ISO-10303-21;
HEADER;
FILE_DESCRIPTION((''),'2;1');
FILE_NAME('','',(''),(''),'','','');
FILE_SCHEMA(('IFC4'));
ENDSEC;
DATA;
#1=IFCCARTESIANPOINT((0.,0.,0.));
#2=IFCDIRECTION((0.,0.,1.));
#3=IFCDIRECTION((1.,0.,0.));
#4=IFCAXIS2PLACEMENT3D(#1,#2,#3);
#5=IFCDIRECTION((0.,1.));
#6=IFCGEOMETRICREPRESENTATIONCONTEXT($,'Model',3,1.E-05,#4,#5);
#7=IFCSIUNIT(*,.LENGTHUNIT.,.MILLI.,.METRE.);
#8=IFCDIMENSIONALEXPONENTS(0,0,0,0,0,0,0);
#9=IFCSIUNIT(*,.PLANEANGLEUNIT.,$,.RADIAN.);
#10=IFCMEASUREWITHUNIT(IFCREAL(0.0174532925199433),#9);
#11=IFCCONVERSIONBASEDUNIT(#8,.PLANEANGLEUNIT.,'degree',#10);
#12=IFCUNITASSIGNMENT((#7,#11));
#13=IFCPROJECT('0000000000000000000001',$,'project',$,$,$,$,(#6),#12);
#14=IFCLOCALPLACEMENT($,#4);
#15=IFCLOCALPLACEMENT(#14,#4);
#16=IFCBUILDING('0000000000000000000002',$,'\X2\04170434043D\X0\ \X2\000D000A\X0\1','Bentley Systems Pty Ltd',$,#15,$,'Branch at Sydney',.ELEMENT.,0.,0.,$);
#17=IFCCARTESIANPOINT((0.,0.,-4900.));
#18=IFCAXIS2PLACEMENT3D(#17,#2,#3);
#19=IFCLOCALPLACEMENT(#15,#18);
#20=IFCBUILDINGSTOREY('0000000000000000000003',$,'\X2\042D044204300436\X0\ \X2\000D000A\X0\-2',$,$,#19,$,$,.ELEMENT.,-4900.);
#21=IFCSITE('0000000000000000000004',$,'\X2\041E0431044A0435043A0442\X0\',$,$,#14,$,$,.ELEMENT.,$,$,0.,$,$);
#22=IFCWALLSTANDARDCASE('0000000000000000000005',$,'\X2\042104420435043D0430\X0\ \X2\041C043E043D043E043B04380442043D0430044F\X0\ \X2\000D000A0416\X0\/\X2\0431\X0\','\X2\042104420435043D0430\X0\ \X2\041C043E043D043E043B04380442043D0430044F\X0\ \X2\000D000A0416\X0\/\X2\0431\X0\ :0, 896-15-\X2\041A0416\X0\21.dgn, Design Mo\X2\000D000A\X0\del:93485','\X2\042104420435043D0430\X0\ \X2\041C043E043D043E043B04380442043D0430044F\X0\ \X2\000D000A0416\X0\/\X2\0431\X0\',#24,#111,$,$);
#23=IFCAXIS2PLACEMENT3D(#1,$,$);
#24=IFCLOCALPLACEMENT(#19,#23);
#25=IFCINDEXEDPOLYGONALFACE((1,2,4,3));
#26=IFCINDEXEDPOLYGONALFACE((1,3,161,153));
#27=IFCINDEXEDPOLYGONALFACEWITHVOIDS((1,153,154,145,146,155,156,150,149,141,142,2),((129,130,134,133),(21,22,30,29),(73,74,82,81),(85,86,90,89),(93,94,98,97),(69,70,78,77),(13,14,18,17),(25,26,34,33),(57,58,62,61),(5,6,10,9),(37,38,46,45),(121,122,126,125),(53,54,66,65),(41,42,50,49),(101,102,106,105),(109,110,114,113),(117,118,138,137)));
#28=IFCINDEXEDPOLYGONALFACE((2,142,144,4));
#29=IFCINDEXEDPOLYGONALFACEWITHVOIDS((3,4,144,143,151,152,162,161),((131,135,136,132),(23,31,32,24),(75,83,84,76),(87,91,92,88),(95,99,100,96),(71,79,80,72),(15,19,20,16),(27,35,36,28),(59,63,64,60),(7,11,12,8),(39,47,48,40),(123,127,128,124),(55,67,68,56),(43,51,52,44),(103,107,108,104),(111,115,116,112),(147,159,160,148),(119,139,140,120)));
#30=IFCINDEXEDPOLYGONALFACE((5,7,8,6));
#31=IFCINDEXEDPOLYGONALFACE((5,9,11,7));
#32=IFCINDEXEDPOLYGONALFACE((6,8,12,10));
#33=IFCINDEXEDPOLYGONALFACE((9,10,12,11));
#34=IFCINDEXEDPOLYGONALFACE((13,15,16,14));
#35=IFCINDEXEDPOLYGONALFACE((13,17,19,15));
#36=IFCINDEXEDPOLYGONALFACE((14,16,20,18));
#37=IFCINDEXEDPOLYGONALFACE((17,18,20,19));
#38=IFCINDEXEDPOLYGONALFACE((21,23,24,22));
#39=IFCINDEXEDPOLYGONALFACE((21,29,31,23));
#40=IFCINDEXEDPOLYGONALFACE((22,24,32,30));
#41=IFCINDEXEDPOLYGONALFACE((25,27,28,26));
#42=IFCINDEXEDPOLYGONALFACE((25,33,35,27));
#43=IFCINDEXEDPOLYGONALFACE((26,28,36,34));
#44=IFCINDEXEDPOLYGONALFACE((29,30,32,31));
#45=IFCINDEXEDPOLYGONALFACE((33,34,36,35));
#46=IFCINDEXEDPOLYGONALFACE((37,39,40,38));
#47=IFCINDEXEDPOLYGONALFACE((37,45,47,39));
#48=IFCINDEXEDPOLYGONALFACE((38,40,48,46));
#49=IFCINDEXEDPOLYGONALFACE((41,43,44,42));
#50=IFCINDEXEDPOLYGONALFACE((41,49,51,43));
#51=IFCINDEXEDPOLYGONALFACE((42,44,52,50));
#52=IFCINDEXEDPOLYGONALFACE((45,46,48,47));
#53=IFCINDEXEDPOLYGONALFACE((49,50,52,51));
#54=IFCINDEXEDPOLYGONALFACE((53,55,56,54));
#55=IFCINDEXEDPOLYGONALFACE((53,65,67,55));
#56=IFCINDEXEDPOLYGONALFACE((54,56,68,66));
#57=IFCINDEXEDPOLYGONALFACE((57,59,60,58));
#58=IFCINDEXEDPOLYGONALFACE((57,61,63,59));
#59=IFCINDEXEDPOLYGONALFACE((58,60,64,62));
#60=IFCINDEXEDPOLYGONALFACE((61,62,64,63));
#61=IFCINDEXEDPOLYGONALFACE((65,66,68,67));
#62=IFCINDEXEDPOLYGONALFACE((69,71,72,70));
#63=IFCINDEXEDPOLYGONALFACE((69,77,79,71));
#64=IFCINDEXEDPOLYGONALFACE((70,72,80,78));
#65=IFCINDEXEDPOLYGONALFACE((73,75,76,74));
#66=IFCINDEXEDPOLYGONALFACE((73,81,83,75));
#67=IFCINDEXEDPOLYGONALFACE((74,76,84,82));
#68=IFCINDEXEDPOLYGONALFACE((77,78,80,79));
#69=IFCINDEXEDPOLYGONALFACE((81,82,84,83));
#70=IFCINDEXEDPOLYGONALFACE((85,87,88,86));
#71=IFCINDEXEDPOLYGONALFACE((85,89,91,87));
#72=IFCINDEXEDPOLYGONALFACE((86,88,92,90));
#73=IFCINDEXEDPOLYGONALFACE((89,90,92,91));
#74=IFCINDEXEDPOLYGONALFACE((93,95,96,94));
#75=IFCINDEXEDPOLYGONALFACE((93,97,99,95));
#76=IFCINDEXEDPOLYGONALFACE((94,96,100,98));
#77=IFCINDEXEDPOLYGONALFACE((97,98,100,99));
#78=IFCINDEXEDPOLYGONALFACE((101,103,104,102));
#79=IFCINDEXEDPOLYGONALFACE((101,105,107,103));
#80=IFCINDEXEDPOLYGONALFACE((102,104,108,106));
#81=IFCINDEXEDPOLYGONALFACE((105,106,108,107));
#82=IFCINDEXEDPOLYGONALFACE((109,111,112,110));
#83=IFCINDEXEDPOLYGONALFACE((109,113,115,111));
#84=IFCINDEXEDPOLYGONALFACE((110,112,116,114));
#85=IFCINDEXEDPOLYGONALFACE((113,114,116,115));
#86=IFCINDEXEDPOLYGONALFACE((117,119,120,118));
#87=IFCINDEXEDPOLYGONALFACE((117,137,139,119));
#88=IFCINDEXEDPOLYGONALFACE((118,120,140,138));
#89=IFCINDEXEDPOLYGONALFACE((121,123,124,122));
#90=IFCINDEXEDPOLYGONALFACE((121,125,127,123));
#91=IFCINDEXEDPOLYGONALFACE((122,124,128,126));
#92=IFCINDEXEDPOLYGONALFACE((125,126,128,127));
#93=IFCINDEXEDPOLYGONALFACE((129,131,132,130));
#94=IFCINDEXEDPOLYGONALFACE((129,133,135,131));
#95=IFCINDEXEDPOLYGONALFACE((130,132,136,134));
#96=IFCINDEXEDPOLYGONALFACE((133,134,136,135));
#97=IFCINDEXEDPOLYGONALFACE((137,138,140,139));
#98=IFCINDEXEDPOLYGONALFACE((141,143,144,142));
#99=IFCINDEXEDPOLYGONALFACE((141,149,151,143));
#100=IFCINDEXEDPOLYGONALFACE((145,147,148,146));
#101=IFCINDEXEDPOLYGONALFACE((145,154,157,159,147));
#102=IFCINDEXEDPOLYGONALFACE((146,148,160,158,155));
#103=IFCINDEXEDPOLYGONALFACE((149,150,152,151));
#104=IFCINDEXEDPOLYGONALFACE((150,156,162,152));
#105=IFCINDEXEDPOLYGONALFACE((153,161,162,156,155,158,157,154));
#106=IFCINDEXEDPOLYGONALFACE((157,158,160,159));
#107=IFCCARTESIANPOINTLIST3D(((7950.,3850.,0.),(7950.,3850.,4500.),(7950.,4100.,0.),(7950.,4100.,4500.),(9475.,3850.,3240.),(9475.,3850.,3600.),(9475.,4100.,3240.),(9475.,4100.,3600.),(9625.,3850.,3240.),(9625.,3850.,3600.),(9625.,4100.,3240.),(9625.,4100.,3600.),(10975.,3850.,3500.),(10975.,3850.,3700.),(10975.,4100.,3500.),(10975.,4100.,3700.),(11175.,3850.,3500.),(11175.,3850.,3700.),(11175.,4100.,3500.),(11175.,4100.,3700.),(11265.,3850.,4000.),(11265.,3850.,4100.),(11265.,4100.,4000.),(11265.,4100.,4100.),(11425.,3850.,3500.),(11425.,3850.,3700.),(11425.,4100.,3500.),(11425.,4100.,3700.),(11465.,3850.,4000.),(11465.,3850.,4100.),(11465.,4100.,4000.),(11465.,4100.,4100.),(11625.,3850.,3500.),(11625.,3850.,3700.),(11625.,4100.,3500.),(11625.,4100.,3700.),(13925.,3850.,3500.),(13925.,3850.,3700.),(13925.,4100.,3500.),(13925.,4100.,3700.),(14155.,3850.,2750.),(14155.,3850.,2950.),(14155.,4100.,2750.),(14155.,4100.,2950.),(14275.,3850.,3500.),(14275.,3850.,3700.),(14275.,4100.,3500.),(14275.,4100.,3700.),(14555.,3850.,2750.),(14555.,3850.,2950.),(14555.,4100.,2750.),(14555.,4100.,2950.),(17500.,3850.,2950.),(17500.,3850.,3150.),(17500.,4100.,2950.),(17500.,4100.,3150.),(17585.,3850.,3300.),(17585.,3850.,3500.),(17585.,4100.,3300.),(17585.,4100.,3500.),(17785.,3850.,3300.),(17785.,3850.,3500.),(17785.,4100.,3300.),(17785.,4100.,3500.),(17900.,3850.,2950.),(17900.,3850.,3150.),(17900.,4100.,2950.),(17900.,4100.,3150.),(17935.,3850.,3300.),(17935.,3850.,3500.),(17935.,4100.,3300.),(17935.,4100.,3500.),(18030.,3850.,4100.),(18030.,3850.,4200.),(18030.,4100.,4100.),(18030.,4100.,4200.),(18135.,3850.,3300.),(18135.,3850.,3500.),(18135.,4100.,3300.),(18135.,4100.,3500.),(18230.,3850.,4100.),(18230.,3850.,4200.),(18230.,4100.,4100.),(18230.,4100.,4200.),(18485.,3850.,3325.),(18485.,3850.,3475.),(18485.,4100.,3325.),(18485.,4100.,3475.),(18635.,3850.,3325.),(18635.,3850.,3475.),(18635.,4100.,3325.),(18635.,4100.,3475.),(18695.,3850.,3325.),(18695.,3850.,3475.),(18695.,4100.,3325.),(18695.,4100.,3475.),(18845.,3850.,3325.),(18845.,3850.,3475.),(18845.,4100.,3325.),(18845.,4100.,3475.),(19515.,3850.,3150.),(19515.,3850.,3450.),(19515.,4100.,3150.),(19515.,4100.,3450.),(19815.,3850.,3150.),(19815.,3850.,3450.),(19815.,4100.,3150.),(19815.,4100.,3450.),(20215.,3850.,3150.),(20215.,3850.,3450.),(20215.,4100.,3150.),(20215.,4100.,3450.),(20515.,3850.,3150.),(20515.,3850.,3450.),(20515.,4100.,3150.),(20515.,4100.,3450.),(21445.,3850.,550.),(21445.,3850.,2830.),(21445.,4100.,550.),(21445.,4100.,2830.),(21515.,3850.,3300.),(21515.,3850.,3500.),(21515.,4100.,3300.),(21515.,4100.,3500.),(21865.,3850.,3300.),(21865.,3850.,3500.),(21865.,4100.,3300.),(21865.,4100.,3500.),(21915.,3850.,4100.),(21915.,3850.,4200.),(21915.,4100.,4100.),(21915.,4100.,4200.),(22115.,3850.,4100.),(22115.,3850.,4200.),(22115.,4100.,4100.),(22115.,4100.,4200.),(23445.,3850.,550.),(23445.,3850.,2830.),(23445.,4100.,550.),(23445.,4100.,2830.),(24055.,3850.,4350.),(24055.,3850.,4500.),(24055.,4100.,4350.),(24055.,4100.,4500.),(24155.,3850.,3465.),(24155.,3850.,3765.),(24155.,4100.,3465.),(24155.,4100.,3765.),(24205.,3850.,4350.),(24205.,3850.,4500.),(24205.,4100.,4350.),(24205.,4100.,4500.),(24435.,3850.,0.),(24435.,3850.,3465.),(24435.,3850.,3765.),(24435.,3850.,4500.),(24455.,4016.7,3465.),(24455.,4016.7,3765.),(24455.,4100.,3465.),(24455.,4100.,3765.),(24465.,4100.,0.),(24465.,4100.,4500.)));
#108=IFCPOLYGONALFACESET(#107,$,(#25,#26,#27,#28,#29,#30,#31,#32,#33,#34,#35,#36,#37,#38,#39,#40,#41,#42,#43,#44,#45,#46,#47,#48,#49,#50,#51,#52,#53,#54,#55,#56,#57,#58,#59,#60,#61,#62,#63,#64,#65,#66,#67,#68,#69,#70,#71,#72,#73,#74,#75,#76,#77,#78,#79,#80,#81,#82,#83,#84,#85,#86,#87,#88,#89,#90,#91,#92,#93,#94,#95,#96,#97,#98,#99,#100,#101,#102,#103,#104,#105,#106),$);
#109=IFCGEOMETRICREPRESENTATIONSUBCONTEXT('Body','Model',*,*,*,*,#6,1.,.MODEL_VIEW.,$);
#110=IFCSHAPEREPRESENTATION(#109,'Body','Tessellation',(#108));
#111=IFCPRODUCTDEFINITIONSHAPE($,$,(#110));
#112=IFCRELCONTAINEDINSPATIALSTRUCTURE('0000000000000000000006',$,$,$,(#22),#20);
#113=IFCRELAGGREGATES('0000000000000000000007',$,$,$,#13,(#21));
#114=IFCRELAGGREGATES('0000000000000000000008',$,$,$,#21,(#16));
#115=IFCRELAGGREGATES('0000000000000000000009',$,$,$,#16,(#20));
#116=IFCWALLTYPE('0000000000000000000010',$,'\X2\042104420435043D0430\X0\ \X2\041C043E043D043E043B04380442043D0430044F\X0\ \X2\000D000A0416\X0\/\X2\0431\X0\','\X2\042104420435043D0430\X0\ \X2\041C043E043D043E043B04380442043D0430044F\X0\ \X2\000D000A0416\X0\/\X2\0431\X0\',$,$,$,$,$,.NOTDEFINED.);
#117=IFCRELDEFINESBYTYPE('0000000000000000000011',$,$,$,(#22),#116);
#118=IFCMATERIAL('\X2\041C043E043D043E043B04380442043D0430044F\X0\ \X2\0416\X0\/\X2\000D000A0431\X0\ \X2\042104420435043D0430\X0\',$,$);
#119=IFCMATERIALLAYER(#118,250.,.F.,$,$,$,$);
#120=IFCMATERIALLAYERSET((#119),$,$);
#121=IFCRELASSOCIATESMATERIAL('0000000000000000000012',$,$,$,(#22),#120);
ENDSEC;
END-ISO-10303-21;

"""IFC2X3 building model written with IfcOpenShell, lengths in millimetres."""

from ifc_helpers import new_model, entity, si_unit, converted_unit, direction, frame, frame_2d, origin_with_axes, place, context, subcontext, project, spatial, polyline, rectangle, outline, extrude, material, layer, layer_set, layer_usage, type_object, element, save


model = new_model("IFC2X3")

# Units and contexts
model_context = context("Model", 3, precision=1e-05, world=origin_with_axes(), true_north=direction((0.0, 1.0)))
body_context = subcontext(model_context, "Body", "Model", "MODEL_VIEW", scale=1.0)
ifc_project = project(units=[si_unit("LENGTHUNIT", "METRE", prefix="MILLI"), converted_unit("PLANEANGLEUNIT", "degree", entity("IfcReal", 0.0174532925199433), si_unit("PLANEANGLEUNIT", "RADIAN"), dimensions=[0, 0, 0, 0, 0, 0, 0])], contexts=[model_context])

# Site, building, storey
site_placement = place(None, origin_with_axes())
site = spatial("IfcSite", under=ifc_project, at=site_placement, Name="Объект", CompositionType="ELEMENT", RefElevation=0.0)
building_placement = place(site_placement, origin_with_axes())
building = spatial("IfcBuilding", under=site, at=building_placement, Name="Здн \r\n1", Description="Bentley Systems Pty Ltd", LongName="Branch at Sydney", CompositionType="ELEMENT", ElevationOfRefHeight=0.0, ElevationOfTerrain=0.0)
storey_placement = place(building_placement, frame((0.0, 0.0, -4900.0), z_axis=(0.0, 0.0, 1.0), x_axis=(1.0, 0.0, 0.0)))
storey = spatial("IfcBuildingStorey", under=building, at=storey_placement, Name="Этаж \r\n-2", CompositionType="ELEMENT", Elevation=-4900.0)

# Wall, openings
ifc_material = material(Name="Монолитная Ж/\r\nб Стена")
ifc_layer_1 = layer(ifc_material, 250.0, ventilated=False)
ifc_layer_set_1 = layer_set([ifc_layer_1])
ifc_layer_usage_1 = layer_usage(ifc_layer_set_1, "AXIS2", "POSITIVE", 0.0)
wall_type = type_object("IfcWallType", Name="Стена Монолитная \r\nЖ/б", Description="Стена Монолитная \r\nЖ/б", PredefinedType="NOTDEFINED")
wall_1_placement = place(storey_placement, frame((7950.0, 3850.0, 0.0), z_axis=(0.0, 0.0, 1.0), x_axis=(1.0, 0.0, 0.0)))
wall_1 = element("IfcWallStandardCase", 1, at=wall_1_placement, inside=storey, type_object=wall_type, material=ifc_layer_usage_1, Name="Стена Монолитная \r\nЖ/б", Description="Стена Монолитная \r\nЖ/б :0, 896-15-КЖ21.dgn, Design Mo\r\ndel:93485", ObjectType="Стена Монолитная \r\nЖ/б", context=body_context, shape_type="SweptSolid", body=[
    extrude(outline(polyline([(16515.0, 250.0), (0.0, 250.0), (0.0, 0.0), (16485.0, 0.0), (16515.0, 250.0)])), origin_with_axes(), (0.0, 0.0, 1.0), 4500.0),
])
opening_1_placement = place(wall_1_placement, frame((13495.0, 0.0, 550.0), z_axis=(0.0, 0.0, 1.0), x_axis=(1.0, 0.0, 0.0)))
element("IfcOpeningElement", 2, at=opening_1_placement, cuts=wall_1, ObjectType="Opening", context=body_context, shape_type="SweptSolid", body=[
    extrude(rectangle(XDim=2280.0, YDim=2000.0, at=frame_2d((-1000.0, 1140.0), x_axis=(0.0, -1.0))), frame((0.0, 0.0, 0.0), z_axis=(0.0, 1.0, 0.0), x_axis=(-1.0, 0.0, 0.0)), (0.0, 0.0, 1.0), 250.0),
])
opening_2_placement = place(wall_1_placement, frame((1525.0, 0.0, 3240.0), z_axis=(0.0, 0.0, 1.0), x_axis=(1.0, 0.0, 0.0)))
element("IfcOpeningElement", 3, at=opening_2_placement, cuts=wall_1, ObjectType="Opening", context=body_context, shape_type="SweptSolid", body=[
    extrude(rectangle(XDim=360.0, YDim=150.0, at=frame_2d((-75.0, 180.0), x_axis=(0.0, -1.0))), frame((0.0, 0.0, 0.0), z_axis=(0.0, 1.0, 0.0), x_axis=(-1.0, 0.0, 0.0)), (0.0, 0.0, 1.0), 250.0),
])
opening_3_placement = place(wall_1_placement, frame((3025.0, 0.0, 3500.0), z_axis=(0.0, 0.0, 1.0), x_axis=(1.0, 0.0, 0.0)))
element("IfcOpeningElement", 4, at=opening_3_placement, cuts=wall_1, ObjectType="Opening", context=body_context, shape_type="SweptSolid", body=[
    extrude(rectangle(XDim=200.0, YDim=200.0, at=frame_2d((-100.0, 100.0), x_axis=(0.0, -1.0))), frame((0.0, 0.0, 0.0), z_axis=(0.0, 1.0, 0.0), x_axis=(-1.0, 0.0, 0.0)), (0.0, 0.0, 1.0), 250.0),
])
opening_4_placement = place(wall_1_placement, frame((3475.0, 0.0, 3500.0), z_axis=(0.0, 0.0, 1.0), x_axis=(1.0, 0.0, 0.0)))
element("IfcOpeningElement", 5, at=opening_4_placement, cuts=wall_1, ObjectType="Opening", context=body_context, shape_type="SweptSolid", body=[
    extrude(rectangle(XDim=200.0, YDim=200.0, at=frame_2d((-100.0, 100.0), x_axis=(0.0, -1.0))), frame((0.0, 0.0, 0.0), z_axis=(0.0, 1.0, 0.0), x_axis=(-1.0, 0.0, 0.0)), (0.0, 0.0, 1.0), 250.0),
])
opening_5_placement = place(wall_1_placement, frame((5975.0, 0.0, 3500.0), z_axis=(0.0, 0.0, 1.0), x_axis=(1.0, 0.0, 0.0)))
element("IfcOpeningElement", 6, at=opening_5_placement, cuts=wall_1, ObjectType="Opening", context=body_context, shape_type="SweptSolid", body=[
    extrude(rectangle(XDim=200.0, YDim=350.0, at=frame_2d((-175.0, 100.0), x_axis=(0.0, -1.0))), frame((0.0, 0.0, 0.0), z_axis=(0.0, 1.0, 0.0), x_axis=(-1.0, 0.0, 0.0)), (0.0, 0.0, 1.0), 250.0),
])
opening_6_placement = place(wall_1_placement, frame((3315.0, 0.0, 4000.0), z_axis=(0.0, 0.0, 1.0), x_axis=(1.0, 0.0, 0.0)))
element("IfcOpeningElement", 7, at=opening_6_placement, cuts=wall_1, ObjectType="Opening", context=body_context, shape_type="SweptSolid", body=[
    extrude(rectangle(XDim=100.0, YDim=200.0, at=frame_2d((-100.0, 50.0), x_axis=(0.0, -1.0))), frame((0.0, 0.0, 0.0), z_axis=(0.0, 1.0, 0.0), x_axis=(-1.0, 0.0, 0.0)), (0.0, 0.0, 1.0), 250.0),
])
opening_7_placement = place(wall_1_placement, frame((6205.0, 0.0, 2750.0), z_axis=(0.0, 0.0, 1.0), x_axis=(1.0, 0.0, 0.0)))
element("IfcOpeningElement", 8, at=opening_7_placement, cuts=wall_1, ObjectType="Opening", context=body_context, shape_type="SweptSolid", body=[
    extrude(rectangle(XDim=200.0, YDim=400.0, at=frame_2d((-200.0, 100.0), x_axis=(0.0, -1.0))), frame((0.0, 0.0, 0.0), z_axis=(0.0, 1.0, 0.0), x_axis=(-1.0, 0.0, 0.0)), (0.0, 0.0, 1.0), 250.0),
])
opening_8_placement = place(wall_1_placement, frame((9635.0, 0.0, 3300.0), z_axis=(0.0, 0.0, 1.0), x_axis=(1.0, 0.0, 0.0)))
element("IfcOpeningElement", 9, at=opening_8_placement, cuts=wall_1, ObjectType="Opening", context=body_context, shape_type="SweptSolid", body=[
    extrude(rectangle(XDim=200.0, YDim=200.0, at=frame_2d((-100.0, 100.0), x_axis=(0.0, -1.0))), frame((0.0, 0.0, 0.0), z_axis=(0.0, 1.0, 0.0), x_axis=(-1.0, 0.0, 0.0)), (0.0, 0.0, 1.0), 250.0),
])
opening_9_placement = place(wall_1_placement, frame((9985.0, 0.0, 3300.0), z_axis=(0.0, 0.0, 1.0), x_axis=(1.0, 0.0, 0.0)))
element("IfcOpeningElement", 10, at=opening_9_placement, cuts=wall_1, ObjectType="Opening", context=body_context, shape_type="SweptSolid", body=[
    extrude(rectangle(XDim=200.0, YDim=200.0, at=frame_2d((-100.0, 100.0), x_axis=(0.0, -1.0))), frame((0.0, 0.0, 0.0), z_axis=(0.0, 1.0, 0.0), x_axis=(-1.0, 0.0, 0.0)), (0.0, 0.0, 1.0), 250.0),
])
opening_10_placement = place(wall_1_placement, frame((10535.0, 0.0, 3325.0), z_axis=(0.0, 0.0, 1.0), x_axis=(1.0, 0.0, 0.0)))
element("IfcOpeningElement", 11, at=opening_10_placement, cuts=wall_1, ObjectType="Opening", context=body_context, shape_type="SweptSolid", body=[
    extrude(rectangle(XDim=150.0, YDim=150.0, at=frame_2d((-75.0, 75.0), x_axis=(0.0, -1.0))), frame((0.0, 0.0, 0.0), z_axis=(0.0, 1.0, 0.0), x_axis=(-1.0, 0.0, 0.0)), (0.0, 0.0, 1.0), 250.0),
])
opening_11_placement = place(wall_1_placement, frame((10745.0, 0.0, 3325.0), z_axis=(0.0, 0.0, 1.0), x_axis=(1.0, 0.0, 0.0)))
element("IfcOpeningElement", 12, at=opening_11_placement, cuts=wall_1, ObjectType="Opening", context=body_context, shape_type="SweptSolid", body=[
    extrude(rectangle(XDim=150.0, YDim=150.0, at=frame_2d((-75.0, 75.0), x_axis=(0.0, -1.0))), frame((0.0, 0.0, 0.0), z_axis=(0.0, 1.0, 0.0), x_axis=(-1.0, 0.0, 0.0)), (0.0, 0.0, 1.0), 250.0),
])
opening_12_placement = place(wall_1_placement, frame((11565.0, 0.0, 3150.0), z_axis=(0.0, 0.0, 1.0), x_axis=(1.0, 0.0, 0.0)))
element("IfcOpeningElement", 13, at=opening_12_placement, cuts=wall_1, ObjectType="Opening", context=body_context, shape_type="SweptSolid", body=[
    extrude(rectangle(XDim=300.0, YDim=300.0, at=frame_2d((-150.0, 150.0), x_axis=(0.0, -1.0))), frame((0.0, 0.0, 0.0), z_axis=(0.0, 1.0, 0.0), x_axis=(-1.0, 0.0, 0.0)), (0.0, 0.0, 1.0), 250.0),
])
opening_13_placement = place(wall_1_placement, frame((12265.0, 0.0, 3150.0), z_axis=(0.0, 0.0, 1.0), x_axis=(1.0, 0.0, 0.0)))
element("IfcOpeningElement", 14, at=opening_13_placement, cuts=wall_1, ObjectType="Opening", context=body_context, shape_type="SweptSolid", body=[
    extrude(rectangle(XDim=300.0, YDim=300.0, at=frame_2d((-150.0, 150.0), x_axis=(0.0, -1.0))), frame((0.0, 0.0, 0.0), z_axis=(0.0, 1.0, 0.0), x_axis=(-1.0, 0.0, 0.0)), (0.0, 0.0, 1.0), 250.0),
])
opening_14_placement = place(wall_1_placement, frame((13565.0, 0.0, 3300.0), z_axis=(0.0, 0.0, 1.0), x_axis=(1.0, 0.0, 0.0)))
element("IfcOpeningElement", 15, at=opening_14_placement, cuts=wall_1, ObjectType="Opening", context=body_context, shape_type="SweptSolid", body=[
    extrude(rectangle(XDim=200.0, YDim=350.0, at=frame_2d((-175.0, 100.0), x_axis=(0.0, -1.0))), frame((0.0, 0.0, 0.0), z_axis=(0.0, 1.0, 0.0), x_axis=(-1.0, 0.0, 0.0)), (0.0, 0.0, 1.0), 250.0),
])
opening_15_placement = place(wall_1_placement, frame((16205.0, 0.0, 3465.0), z_axis=(0.0, 0.0, 1.0), x_axis=(1.0, 0.0, 0.0)))
element("IfcOpeningElement", 16, at=opening_15_placement, cuts=wall_1, ObjectType="Opening", context=body_context, shape_type="SweptSolid", body=[
    extrude(rectangle(XDim=300.0, YDim=300.0, at=frame_2d((-150.0, 150.0), x_axis=(0.0, -1.0))), frame((0.0, 0.0, 0.0), z_axis=(0.0, 1.0, 0.0), x_axis=(-1.0, 0.0, 0.0)), (0.0, 0.0, 1.0), 250.0),
])
opening_16_placement = place(wall_1_placement, frame((9550.0, 0.0, 2950.0), z_axis=(0.0, 0.0, 1.0), x_axis=(1.0, 0.0, 0.0)))
element("IfcOpeningElement", 17, at=opening_16_placement, cuts=wall_1, ObjectType="Opening", context=body_context, shape_type="SweptSolid", body=[
    extrude(rectangle(XDim=200.0, YDim=400.0, at=frame_2d((-200.0, 100.0), x_axis=(0.0, -1.0))), frame((0.0, 0.0, 0.0), z_axis=(0.0, 1.0, 0.0), x_axis=(-1.0, 0.0, 0.0)), (0.0, 0.0, 1.0), 250.0),
])
opening_17_placement = place(wall_1_placement, frame((10080.0, 0.0, 4100.0), z_axis=(0.0, 0.0, 1.0), x_axis=(1.0, 0.0, 0.0)))
element("IfcOpeningElement", 18, at=opening_17_placement, cuts=wall_1, ObjectType="Opening", context=body_context, shape_type="SweptSolid", body=[
    extrude(rectangle(XDim=100.0, YDim=200.0, at=frame_2d((-100.0, 50.0), x_axis=(0.0, -1.0))), frame((0.0, 0.0, 0.0), z_axis=(0.0, 1.0, 0.0), x_axis=(-1.0, 0.0, 0.0)), (0.0, 0.0, 1.0), 250.0),
])
opening_18_placement = place(wall_1_placement, frame((13965.0, 0.0, 4100.0), z_axis=(0.0, 0.0, 1.0), x_axis=(1.0, 0.0, 0.0)))
element("IfcOpeningElement", 19, at=opening_18_placement, cuts=wall_1, ObjectType="Opening", context=body_context, shape_type="SweptSolid", body=[
    extrude(rectangle(XDim=100.0, YDim=200.0, at=frame_2d((-100.0, 50.0), x_axis=(0.0, -1.0))), frame((0.0, 0.0, 0.0), z_axis=(0.0, 1.0, 0.0), x_axis=(-1.0, 0.0, 0.0)), (0.0, 0.0, 1.0), 250.0),
])
opening_19_placement = place(wall_1_placement, frame((16105.0, 0.0, 4350.0), z_axis=(0.0, 0.0, 1.0), x_axis=(1.0, 0.0, 0.0)))
element("IfcOpeningElement", 20, at=opening_19_placement, cuts=wall_1, ObjectType="Opening", context=body_context, shape_type="SweptSolid", body=[
    extrude(rectangle(XDim=150.0, YDim=150.0, at=frame_2d((-75.0, 75.0), x_axis=(0.0, -1.0))), frame((0.0, 0.0, 0.0), z_axis=(0.0, 1.0, 0.0), x_axis=(-1.0, 0.0, 0.0)), (0.0, 0.0, 1.0), 250.0),
])

save(model, "model.ifc")
